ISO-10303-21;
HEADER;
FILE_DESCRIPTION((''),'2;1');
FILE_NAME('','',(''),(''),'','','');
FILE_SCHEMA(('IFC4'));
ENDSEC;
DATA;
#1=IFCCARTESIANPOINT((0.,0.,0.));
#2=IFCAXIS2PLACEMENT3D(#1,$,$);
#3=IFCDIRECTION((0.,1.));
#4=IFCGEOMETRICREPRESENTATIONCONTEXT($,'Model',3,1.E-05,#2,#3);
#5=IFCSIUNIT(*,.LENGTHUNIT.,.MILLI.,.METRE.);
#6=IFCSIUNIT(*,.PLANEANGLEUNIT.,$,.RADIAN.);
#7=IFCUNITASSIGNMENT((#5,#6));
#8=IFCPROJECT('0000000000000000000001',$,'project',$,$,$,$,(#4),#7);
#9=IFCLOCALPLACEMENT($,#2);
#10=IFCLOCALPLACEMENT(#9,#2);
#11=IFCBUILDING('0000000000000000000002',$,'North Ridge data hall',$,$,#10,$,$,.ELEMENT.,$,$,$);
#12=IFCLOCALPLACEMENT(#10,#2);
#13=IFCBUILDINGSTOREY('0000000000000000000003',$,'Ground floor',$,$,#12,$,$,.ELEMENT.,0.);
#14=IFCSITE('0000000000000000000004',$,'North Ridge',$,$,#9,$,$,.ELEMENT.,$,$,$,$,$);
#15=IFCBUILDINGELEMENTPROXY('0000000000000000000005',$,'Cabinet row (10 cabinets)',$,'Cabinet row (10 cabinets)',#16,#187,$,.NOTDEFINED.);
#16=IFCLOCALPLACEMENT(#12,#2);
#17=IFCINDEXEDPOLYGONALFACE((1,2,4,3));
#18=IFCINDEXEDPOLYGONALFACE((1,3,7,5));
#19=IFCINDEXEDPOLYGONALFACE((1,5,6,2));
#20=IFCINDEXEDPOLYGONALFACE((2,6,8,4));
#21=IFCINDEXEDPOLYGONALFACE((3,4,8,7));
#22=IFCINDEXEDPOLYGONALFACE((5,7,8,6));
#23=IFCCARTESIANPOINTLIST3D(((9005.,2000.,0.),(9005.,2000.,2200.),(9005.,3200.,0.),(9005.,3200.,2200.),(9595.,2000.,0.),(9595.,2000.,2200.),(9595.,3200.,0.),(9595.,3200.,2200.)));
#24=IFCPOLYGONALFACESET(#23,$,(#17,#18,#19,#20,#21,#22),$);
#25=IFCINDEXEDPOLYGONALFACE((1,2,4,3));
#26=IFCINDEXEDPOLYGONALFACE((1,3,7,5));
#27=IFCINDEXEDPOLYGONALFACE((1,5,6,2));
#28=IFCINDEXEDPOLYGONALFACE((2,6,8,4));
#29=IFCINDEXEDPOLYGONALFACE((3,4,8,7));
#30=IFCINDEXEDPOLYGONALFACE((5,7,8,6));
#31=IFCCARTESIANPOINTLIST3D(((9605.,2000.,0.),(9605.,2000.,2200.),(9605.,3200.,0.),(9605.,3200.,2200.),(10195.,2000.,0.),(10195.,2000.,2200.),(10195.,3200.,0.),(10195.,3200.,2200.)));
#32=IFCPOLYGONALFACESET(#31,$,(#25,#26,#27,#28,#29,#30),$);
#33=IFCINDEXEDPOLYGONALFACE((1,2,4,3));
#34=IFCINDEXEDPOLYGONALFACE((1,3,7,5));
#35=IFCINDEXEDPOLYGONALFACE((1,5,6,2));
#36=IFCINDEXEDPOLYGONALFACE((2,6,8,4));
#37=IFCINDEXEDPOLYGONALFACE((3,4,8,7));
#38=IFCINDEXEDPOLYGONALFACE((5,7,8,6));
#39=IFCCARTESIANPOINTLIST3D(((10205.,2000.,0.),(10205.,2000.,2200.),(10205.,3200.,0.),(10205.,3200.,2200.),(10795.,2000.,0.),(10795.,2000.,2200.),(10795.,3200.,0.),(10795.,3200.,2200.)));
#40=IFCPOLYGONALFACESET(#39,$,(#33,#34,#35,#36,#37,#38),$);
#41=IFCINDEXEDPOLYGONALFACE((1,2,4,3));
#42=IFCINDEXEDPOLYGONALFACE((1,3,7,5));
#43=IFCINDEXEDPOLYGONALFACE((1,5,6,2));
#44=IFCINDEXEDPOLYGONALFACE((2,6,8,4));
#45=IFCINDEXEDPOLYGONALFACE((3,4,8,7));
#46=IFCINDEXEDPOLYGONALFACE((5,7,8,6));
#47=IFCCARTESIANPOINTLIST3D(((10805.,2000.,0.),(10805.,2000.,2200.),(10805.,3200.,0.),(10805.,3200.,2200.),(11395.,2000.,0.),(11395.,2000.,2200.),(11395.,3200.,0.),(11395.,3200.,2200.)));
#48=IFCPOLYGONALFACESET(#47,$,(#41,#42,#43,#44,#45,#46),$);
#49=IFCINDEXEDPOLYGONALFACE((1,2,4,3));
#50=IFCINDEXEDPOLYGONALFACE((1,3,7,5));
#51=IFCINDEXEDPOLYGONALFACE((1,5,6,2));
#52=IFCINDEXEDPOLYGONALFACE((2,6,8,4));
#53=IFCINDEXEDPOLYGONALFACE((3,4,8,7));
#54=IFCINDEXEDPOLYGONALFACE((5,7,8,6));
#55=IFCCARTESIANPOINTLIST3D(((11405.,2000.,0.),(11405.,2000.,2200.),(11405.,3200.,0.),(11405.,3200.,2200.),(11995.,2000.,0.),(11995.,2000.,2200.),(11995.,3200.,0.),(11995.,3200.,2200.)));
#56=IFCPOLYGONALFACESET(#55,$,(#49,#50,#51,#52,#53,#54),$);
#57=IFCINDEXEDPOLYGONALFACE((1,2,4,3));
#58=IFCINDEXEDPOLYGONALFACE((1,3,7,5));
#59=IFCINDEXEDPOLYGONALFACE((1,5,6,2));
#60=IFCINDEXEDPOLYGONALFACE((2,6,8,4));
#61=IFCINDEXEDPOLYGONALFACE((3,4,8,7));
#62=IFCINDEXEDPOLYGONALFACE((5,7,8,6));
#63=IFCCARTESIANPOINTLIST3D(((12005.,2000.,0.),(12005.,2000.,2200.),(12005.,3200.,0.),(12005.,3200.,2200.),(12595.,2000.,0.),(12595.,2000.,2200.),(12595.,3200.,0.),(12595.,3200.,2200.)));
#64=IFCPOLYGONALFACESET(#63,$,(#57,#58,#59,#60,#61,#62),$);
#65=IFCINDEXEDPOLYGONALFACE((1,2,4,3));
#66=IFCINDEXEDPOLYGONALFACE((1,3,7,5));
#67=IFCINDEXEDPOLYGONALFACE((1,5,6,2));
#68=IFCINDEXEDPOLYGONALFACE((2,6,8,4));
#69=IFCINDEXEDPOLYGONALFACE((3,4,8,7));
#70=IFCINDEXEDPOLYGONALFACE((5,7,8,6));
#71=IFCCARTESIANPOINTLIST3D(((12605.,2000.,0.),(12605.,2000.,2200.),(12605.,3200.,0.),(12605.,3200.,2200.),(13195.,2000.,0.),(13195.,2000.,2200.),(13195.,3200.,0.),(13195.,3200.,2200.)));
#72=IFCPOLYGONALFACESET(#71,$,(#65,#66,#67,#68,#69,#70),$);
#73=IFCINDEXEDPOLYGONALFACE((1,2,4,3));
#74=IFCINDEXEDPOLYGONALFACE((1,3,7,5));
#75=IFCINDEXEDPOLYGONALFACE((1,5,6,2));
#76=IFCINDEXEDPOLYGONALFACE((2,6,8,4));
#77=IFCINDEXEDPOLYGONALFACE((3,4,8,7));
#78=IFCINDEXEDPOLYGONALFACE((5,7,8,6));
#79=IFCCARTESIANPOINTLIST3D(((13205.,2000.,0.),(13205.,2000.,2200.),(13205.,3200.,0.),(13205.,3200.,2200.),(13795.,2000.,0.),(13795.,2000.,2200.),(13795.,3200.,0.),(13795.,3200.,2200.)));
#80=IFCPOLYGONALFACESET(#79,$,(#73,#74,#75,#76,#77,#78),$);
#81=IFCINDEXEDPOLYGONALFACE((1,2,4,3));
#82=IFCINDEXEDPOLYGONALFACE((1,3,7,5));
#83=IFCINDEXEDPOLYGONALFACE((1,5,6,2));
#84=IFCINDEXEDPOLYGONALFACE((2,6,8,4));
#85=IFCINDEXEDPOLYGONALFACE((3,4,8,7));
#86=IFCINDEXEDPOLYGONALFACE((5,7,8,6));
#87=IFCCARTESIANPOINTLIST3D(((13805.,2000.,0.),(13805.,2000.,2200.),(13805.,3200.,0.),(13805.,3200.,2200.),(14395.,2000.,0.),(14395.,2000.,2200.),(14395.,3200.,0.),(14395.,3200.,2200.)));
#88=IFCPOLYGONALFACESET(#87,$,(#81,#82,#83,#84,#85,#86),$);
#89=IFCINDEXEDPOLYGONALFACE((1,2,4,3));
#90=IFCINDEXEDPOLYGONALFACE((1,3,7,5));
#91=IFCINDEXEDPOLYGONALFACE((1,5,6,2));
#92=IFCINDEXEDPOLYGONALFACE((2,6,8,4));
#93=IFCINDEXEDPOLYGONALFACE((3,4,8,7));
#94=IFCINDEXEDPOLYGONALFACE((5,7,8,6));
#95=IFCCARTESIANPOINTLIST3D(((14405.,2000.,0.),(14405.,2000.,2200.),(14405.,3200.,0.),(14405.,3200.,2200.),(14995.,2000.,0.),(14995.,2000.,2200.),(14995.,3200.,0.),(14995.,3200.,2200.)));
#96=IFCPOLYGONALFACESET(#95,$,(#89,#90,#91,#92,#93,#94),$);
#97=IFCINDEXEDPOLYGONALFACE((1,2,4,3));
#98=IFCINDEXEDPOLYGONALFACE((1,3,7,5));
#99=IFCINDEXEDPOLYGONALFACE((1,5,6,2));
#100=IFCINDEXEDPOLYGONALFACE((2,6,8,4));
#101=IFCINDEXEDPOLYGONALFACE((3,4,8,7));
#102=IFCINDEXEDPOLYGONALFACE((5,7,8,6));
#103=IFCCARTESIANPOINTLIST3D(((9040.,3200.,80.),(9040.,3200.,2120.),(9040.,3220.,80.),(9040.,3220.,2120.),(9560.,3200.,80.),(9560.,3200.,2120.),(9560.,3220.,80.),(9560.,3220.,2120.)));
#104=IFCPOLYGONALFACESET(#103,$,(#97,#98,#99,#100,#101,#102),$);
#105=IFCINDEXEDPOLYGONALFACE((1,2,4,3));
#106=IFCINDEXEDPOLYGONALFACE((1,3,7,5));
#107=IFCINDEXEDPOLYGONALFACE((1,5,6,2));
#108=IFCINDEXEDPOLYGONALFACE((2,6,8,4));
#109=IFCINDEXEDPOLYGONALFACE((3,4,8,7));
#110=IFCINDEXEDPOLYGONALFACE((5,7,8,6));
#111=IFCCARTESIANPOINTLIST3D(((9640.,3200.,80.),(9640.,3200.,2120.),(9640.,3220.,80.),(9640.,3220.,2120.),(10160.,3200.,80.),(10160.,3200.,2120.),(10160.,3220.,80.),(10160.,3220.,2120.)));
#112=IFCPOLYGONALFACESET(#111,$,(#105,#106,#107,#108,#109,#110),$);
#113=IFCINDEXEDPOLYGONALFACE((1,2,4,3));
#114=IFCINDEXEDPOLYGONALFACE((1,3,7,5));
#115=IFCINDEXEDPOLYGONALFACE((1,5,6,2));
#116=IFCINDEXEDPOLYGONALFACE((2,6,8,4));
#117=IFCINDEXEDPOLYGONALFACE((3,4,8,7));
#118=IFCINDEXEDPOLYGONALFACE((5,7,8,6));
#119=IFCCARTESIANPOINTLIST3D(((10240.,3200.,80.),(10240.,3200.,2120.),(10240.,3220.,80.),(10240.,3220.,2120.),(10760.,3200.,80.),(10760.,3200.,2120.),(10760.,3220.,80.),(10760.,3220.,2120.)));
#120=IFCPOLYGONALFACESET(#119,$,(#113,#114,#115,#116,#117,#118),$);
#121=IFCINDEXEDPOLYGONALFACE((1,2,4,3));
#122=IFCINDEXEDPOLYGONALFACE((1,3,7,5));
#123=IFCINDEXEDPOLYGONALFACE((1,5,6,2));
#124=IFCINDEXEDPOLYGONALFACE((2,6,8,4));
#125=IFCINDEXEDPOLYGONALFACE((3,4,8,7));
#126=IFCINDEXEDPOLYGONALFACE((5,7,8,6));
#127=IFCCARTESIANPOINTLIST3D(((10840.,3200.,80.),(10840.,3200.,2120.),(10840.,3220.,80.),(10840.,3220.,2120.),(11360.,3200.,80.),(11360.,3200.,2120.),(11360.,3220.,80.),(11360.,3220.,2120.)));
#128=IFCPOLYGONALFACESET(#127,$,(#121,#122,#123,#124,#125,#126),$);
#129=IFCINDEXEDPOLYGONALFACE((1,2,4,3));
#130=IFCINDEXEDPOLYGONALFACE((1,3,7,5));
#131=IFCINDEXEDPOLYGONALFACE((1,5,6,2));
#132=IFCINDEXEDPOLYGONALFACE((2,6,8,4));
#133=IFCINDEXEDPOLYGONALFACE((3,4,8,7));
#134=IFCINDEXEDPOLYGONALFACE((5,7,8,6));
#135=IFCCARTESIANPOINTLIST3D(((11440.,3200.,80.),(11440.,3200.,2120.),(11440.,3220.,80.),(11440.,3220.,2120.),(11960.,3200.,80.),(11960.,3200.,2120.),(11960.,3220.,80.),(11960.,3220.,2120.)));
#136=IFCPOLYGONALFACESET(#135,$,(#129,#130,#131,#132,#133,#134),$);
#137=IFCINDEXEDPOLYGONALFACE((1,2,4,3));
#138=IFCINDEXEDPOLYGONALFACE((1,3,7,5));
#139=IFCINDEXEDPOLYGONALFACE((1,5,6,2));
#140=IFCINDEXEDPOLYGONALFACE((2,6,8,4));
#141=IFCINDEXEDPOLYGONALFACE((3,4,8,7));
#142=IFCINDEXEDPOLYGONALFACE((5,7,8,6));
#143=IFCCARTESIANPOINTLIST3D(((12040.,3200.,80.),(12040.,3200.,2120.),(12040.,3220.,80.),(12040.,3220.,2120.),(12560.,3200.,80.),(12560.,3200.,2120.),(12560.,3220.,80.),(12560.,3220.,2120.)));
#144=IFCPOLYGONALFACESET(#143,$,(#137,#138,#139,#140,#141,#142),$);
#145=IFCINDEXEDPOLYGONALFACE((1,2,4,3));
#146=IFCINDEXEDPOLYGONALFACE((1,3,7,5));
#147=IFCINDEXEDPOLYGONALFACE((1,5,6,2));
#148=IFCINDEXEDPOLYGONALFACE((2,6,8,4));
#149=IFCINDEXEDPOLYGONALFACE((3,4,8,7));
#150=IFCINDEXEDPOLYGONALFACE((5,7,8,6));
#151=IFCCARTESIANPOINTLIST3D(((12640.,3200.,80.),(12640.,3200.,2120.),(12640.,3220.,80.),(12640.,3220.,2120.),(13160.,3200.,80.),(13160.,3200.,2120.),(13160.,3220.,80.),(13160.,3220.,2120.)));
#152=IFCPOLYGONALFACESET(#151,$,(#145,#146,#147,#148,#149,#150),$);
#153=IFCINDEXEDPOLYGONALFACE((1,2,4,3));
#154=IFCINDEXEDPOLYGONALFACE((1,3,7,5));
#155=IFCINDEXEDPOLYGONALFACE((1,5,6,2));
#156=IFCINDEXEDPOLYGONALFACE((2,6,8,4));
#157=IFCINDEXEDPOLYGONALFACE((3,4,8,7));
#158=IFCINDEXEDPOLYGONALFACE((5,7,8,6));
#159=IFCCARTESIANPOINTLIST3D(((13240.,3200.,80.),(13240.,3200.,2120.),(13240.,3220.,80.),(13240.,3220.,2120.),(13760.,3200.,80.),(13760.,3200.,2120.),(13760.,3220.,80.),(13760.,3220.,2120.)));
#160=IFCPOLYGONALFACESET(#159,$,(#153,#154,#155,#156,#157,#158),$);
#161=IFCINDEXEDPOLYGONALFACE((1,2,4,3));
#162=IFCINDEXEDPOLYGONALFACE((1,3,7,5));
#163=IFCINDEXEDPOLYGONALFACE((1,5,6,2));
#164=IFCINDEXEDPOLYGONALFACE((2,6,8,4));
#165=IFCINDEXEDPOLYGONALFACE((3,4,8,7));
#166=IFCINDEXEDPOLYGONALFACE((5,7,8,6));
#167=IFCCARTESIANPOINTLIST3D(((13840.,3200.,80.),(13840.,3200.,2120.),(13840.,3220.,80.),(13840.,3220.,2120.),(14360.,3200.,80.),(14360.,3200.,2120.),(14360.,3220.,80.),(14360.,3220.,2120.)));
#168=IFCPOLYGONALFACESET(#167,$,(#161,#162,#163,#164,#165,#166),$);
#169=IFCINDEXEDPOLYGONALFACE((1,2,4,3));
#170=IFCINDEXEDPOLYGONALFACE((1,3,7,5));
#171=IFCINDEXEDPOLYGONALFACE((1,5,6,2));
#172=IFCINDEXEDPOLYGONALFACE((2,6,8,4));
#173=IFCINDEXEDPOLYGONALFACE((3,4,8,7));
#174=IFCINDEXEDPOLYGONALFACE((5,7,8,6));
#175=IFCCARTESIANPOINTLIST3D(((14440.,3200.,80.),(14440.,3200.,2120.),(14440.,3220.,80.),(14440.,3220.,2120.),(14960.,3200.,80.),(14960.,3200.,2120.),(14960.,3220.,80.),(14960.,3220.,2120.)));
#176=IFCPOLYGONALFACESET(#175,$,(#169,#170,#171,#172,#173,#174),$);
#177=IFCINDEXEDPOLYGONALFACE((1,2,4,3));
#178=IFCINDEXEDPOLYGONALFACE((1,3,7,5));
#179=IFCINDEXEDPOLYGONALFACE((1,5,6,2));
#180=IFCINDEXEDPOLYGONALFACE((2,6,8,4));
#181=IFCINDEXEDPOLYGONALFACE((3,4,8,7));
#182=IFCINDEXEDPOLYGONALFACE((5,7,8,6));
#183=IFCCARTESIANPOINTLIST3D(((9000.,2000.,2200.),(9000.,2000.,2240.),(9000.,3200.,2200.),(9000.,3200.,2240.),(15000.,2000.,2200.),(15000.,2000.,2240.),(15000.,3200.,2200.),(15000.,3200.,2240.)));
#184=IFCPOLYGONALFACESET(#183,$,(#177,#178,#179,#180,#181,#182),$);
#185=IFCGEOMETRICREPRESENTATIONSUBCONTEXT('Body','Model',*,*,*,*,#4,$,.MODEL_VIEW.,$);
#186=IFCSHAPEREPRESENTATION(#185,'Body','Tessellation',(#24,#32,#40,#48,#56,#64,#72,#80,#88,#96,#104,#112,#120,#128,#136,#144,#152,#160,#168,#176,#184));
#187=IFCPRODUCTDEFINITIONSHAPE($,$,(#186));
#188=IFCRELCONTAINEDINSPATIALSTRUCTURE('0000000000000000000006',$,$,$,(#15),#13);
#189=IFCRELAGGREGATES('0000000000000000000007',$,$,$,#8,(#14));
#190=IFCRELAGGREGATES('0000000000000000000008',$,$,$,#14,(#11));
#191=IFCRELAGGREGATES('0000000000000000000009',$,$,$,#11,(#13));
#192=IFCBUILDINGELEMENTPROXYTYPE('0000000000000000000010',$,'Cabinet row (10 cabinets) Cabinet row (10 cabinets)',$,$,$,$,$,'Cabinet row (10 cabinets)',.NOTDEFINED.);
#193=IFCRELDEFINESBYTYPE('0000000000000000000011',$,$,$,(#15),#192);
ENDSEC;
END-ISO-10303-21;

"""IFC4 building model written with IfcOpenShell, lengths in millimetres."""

from ifc_helpers import new_model, si_unit, direction, frame, origin, place, context, subcontext, project, spatial, polyline, outline, extrude, source, transform, mapped, type_object, type_shapes, element, save


model = new_model("IFC4")

# Units and contexts
model_context = context("Model", 3, precision=1e-05, world=origin(), true_north=direction((0.0, 1.0)))
body_context = subcontext(model_context, "Body", "Model", "MODEL_VIEW")
ifc_project = project(units=[si_unit("LENGTHUNIT", "METRE", prefix="MILLI"), si_unit("PLANEANGLEUNIT", "RADIAN")], contexts=[model_context])

# Site, building, storey
site_placement = place(None, origin())
site = spatial("IfcSite", under=ifc_project, at=site_placement, Name="North Ridge", CompositionType="ELEMENT")
building_placement = place(site_placement, origin())
building = spatial("IfcBuilding", under=site, at=building_placement, Name="North Ridge data hall", CompositionType="ELEMENT")
storey_placement = place(building_placement, origin())
storey = spatial("IfcBuildingStorey", under=building, at=storey_placement, Name="Ground floor", CompositionType="ELEMENT", Elevation=0.0)

# Building element proxy
building_element_proxy_type_1 = type_object("IfcBuildingElementProxyType", Name="Cabinet row (10 cabinets) Cabinet row (10 cabinets)", ElementType="Cabinet row (10 cabinets)", PredefinedType="NOTDEFINED")
shared_shape_1 = source(origin(), body_context, "Body", "SweptSolid", [
    extrude(outline(polyline([(5.0, 0.0), (595.0, 0.0), (595.0, 1200.0), (5.0, 1200.0), (5.0, 0.0)])), origin(), (0.0, 0.0, 1.0), 2200.0),
    extrude(outline(polyline([(605.0, 0.0), (1195.0, 0.0), (1195.0, 1200.0), (605.0, 1200.0), (605.0, 0.0)])), origin(), (0.0, 0.0, 1.0), 2200.0),
    extrude(outline(polyline([(1205.0, 0.0), (1795.0, 0.0), (1795.0, 1200.0), (1205.0, 1200.0), (1205.0, 0.0)])), origin(), (0.0, 0.0, 1.0), 2200.0),
    extrude(outline(polyline([(1805.0, 0.0), (2395.0, 0.0), (2395.0, 1200.0), (1805.0, 1200.0), (1805.0, 0.0)])), origin(), (0.0, 0.0, 1.0), 2200.0),
    extrude(outline(polyline([(2405.0, 0.0), (2995.0, 0.0), (2995.0, 1200.0), (2405.0, 1200.0), (2405.0, 0.0)])), origin(), (0.0, 0.0, 1.0), 2200.0),
    extrude(outline(polyline([(3005.0, 0.0), (3595.0, 0.0), (3595.0, 1200.0), (3005.0, 1200.0), (3005.0, 0.0)])), origin(), (0.0, 0.0, 1.0), 2200.0),
    extrude(outline(polyline([(3605.0, 0.0), (4195.0, 0.0), (4195.0, 1200.0), (3605.0, 1200.0), (3605.0, 0.0)])), origin(), (0.0, 0.0, 1.0), 2200.0),
    extrude(outline(polyline([(4205.0, 0.0), (4795.0, 0.0), (4795.0, 1200.0), (4205.0, 1200.0), (4205.0, 0.0)])), origin(), (0.0, 0.0, 1.0), 2200.0),
    extrude(outline(polyline([(4805.0, 0.0), (5395.0, 0.0), (5395.0, 1200.0), (4805.0, 1200.0), (4805.0, 0.0)])), origin(), (0.0, 0.0, 1.0), 2200.0),
    extrude(outline(polyline([(5405.0, 0.0), (5995.0, 0.0), (5995.0, 1200.0), (5405.0, 1200.0), (5405.0, 0.0)])), origin(), (0.0, 0.0, 1.0), 2200.0),
    extrude(outline(polyline([(40.0, 1200.0), (560.0, 1200.0), (560.0, 1220.0), (40.0, 1220.0), (40.0, 1200.0)])), frame((0.0, 0.0, 80.0)), (0.0, 0.0, 1.0), 2040.0),
    extrude(outline(polyline([(640.0, 1200.0), (1160.0, 1200.0), (1160.0, 1220.0), (640.0, 1220.0), (640.0, 1200.0)])), frame((0.0, 0.0, 80.0)), (0.0, 0.0, 1.0), 2040.0),
    extrude(outline(polyline([(1240.0, 1200.0), (1760.0, 1200.0), (1760.0, 1220.0), (1240.0, 1220.0), (1240.0, 1200.0)])), frame((0.0, 0.0, 80.0)), (0.0, 0.0, 1.0), 2040.0),
    extrude(outline(polyline([(1840.0, 1200.0), (2360.0, 1200.0), (2360.0, 1220.0), (1840.0, 1220.0), (1840.0, 1200.0)])), frame((0.0, 0.0, 80.0)), (0.0, 0.0, 1.0), 2040.0),
    extrude(outline(polyline([(2440.0, 1200.0), (2960.0, 1200.0), (2960.0, 1220.0), (2440.0, 1220.0), (2440.0, 1200.0)])), frame((0.0, 0.0, 80.0)), (0.0, 0.0, 1.0), 2040.0),
    extrude(outline(polyline([(3040.0, 1200.0), (3560.0, 1200.0), (3560.0, 1220.0), (3040.0, 1220.0), (3040.0, 1200.0)])), frame((0.0, 0.0, 80.0)), (0.0, 0.0, 1.0), 2040.0),
    extrude(outline(polyline([(3640.0, 1200.0), (4160.0, 1200.0), (4160.0, 1220.0), (3640.0, 1220.0), (3640.0, 1200.0)])), frame((0.0, 0.0, 80.0)), (0.0, 0.0, 1.0), 2040.0),
    extrude(outline(polyline([(4240.0, 1200.0), (4760.0, 1200.0), (4760.0, 1220.0), (4240.0, 1220.0), (4240.0, 1200.0)])), frame((0.0, 0.0, 80.0)), (0.0, 0.0, 1.0), 2040.0),
    extrude(outline(polyline([(4840.0, 1200.0), (5360.0, 1200.0), (5360.0, 1220.0), (4840.0, 1220.0), (4840.0, 1200.0)])), frame((0.0, 0.0, 80.0)), (0.0, 0.0, 1.0), 2040.0),
    extrude(outline(polyline([(5440.0, 1200.0), (5960.0, 1200.0), (5960.0, 1220.0), (5440.0, 1220.0), (5440.0, 1200.0)])), frame((0.0, 0.0, 80.0)), (0.0, 0.0, 1.0), 2040.0),
    extrude(outline(polyline([(0.0, 0.0), (6000.0, 0.0), (6000.0, 1200.0), (0.0, 1200.0), (0.0, 0.0)])), frame((0.0, 0.0, 2200.0)), (0.0, 0.0, 1.0), 40.0),
])
type_shapes(building_element_proxy_type_1, [shared_shape_1])
for number, where, z_axis, x_axis, name in (
    (1, (9000.0, 2000.0, 0.0), (0.0, 0.0, 1.0), (1.0, 0.0, 0.0), "Cabinet row (10 cabinets)"),
):
    element("IfcBuildingElementProxy", number, at=place(storey_placement, frame(where, z_axis=z_axis, x_axis=x_axis)), inside=storey, type_object=building_element_proxy_type_1, Name=name, ObjectType="Cabinet row (10 cabinets)", PredefinedType="NOTDEFINED", context=body_context, shape_type="MappedRepresentation", body=[
        mapped(shared_shape_1, transform((0.0, 0.0, 0.0))),
    ])

save(model, "model.ifc")
